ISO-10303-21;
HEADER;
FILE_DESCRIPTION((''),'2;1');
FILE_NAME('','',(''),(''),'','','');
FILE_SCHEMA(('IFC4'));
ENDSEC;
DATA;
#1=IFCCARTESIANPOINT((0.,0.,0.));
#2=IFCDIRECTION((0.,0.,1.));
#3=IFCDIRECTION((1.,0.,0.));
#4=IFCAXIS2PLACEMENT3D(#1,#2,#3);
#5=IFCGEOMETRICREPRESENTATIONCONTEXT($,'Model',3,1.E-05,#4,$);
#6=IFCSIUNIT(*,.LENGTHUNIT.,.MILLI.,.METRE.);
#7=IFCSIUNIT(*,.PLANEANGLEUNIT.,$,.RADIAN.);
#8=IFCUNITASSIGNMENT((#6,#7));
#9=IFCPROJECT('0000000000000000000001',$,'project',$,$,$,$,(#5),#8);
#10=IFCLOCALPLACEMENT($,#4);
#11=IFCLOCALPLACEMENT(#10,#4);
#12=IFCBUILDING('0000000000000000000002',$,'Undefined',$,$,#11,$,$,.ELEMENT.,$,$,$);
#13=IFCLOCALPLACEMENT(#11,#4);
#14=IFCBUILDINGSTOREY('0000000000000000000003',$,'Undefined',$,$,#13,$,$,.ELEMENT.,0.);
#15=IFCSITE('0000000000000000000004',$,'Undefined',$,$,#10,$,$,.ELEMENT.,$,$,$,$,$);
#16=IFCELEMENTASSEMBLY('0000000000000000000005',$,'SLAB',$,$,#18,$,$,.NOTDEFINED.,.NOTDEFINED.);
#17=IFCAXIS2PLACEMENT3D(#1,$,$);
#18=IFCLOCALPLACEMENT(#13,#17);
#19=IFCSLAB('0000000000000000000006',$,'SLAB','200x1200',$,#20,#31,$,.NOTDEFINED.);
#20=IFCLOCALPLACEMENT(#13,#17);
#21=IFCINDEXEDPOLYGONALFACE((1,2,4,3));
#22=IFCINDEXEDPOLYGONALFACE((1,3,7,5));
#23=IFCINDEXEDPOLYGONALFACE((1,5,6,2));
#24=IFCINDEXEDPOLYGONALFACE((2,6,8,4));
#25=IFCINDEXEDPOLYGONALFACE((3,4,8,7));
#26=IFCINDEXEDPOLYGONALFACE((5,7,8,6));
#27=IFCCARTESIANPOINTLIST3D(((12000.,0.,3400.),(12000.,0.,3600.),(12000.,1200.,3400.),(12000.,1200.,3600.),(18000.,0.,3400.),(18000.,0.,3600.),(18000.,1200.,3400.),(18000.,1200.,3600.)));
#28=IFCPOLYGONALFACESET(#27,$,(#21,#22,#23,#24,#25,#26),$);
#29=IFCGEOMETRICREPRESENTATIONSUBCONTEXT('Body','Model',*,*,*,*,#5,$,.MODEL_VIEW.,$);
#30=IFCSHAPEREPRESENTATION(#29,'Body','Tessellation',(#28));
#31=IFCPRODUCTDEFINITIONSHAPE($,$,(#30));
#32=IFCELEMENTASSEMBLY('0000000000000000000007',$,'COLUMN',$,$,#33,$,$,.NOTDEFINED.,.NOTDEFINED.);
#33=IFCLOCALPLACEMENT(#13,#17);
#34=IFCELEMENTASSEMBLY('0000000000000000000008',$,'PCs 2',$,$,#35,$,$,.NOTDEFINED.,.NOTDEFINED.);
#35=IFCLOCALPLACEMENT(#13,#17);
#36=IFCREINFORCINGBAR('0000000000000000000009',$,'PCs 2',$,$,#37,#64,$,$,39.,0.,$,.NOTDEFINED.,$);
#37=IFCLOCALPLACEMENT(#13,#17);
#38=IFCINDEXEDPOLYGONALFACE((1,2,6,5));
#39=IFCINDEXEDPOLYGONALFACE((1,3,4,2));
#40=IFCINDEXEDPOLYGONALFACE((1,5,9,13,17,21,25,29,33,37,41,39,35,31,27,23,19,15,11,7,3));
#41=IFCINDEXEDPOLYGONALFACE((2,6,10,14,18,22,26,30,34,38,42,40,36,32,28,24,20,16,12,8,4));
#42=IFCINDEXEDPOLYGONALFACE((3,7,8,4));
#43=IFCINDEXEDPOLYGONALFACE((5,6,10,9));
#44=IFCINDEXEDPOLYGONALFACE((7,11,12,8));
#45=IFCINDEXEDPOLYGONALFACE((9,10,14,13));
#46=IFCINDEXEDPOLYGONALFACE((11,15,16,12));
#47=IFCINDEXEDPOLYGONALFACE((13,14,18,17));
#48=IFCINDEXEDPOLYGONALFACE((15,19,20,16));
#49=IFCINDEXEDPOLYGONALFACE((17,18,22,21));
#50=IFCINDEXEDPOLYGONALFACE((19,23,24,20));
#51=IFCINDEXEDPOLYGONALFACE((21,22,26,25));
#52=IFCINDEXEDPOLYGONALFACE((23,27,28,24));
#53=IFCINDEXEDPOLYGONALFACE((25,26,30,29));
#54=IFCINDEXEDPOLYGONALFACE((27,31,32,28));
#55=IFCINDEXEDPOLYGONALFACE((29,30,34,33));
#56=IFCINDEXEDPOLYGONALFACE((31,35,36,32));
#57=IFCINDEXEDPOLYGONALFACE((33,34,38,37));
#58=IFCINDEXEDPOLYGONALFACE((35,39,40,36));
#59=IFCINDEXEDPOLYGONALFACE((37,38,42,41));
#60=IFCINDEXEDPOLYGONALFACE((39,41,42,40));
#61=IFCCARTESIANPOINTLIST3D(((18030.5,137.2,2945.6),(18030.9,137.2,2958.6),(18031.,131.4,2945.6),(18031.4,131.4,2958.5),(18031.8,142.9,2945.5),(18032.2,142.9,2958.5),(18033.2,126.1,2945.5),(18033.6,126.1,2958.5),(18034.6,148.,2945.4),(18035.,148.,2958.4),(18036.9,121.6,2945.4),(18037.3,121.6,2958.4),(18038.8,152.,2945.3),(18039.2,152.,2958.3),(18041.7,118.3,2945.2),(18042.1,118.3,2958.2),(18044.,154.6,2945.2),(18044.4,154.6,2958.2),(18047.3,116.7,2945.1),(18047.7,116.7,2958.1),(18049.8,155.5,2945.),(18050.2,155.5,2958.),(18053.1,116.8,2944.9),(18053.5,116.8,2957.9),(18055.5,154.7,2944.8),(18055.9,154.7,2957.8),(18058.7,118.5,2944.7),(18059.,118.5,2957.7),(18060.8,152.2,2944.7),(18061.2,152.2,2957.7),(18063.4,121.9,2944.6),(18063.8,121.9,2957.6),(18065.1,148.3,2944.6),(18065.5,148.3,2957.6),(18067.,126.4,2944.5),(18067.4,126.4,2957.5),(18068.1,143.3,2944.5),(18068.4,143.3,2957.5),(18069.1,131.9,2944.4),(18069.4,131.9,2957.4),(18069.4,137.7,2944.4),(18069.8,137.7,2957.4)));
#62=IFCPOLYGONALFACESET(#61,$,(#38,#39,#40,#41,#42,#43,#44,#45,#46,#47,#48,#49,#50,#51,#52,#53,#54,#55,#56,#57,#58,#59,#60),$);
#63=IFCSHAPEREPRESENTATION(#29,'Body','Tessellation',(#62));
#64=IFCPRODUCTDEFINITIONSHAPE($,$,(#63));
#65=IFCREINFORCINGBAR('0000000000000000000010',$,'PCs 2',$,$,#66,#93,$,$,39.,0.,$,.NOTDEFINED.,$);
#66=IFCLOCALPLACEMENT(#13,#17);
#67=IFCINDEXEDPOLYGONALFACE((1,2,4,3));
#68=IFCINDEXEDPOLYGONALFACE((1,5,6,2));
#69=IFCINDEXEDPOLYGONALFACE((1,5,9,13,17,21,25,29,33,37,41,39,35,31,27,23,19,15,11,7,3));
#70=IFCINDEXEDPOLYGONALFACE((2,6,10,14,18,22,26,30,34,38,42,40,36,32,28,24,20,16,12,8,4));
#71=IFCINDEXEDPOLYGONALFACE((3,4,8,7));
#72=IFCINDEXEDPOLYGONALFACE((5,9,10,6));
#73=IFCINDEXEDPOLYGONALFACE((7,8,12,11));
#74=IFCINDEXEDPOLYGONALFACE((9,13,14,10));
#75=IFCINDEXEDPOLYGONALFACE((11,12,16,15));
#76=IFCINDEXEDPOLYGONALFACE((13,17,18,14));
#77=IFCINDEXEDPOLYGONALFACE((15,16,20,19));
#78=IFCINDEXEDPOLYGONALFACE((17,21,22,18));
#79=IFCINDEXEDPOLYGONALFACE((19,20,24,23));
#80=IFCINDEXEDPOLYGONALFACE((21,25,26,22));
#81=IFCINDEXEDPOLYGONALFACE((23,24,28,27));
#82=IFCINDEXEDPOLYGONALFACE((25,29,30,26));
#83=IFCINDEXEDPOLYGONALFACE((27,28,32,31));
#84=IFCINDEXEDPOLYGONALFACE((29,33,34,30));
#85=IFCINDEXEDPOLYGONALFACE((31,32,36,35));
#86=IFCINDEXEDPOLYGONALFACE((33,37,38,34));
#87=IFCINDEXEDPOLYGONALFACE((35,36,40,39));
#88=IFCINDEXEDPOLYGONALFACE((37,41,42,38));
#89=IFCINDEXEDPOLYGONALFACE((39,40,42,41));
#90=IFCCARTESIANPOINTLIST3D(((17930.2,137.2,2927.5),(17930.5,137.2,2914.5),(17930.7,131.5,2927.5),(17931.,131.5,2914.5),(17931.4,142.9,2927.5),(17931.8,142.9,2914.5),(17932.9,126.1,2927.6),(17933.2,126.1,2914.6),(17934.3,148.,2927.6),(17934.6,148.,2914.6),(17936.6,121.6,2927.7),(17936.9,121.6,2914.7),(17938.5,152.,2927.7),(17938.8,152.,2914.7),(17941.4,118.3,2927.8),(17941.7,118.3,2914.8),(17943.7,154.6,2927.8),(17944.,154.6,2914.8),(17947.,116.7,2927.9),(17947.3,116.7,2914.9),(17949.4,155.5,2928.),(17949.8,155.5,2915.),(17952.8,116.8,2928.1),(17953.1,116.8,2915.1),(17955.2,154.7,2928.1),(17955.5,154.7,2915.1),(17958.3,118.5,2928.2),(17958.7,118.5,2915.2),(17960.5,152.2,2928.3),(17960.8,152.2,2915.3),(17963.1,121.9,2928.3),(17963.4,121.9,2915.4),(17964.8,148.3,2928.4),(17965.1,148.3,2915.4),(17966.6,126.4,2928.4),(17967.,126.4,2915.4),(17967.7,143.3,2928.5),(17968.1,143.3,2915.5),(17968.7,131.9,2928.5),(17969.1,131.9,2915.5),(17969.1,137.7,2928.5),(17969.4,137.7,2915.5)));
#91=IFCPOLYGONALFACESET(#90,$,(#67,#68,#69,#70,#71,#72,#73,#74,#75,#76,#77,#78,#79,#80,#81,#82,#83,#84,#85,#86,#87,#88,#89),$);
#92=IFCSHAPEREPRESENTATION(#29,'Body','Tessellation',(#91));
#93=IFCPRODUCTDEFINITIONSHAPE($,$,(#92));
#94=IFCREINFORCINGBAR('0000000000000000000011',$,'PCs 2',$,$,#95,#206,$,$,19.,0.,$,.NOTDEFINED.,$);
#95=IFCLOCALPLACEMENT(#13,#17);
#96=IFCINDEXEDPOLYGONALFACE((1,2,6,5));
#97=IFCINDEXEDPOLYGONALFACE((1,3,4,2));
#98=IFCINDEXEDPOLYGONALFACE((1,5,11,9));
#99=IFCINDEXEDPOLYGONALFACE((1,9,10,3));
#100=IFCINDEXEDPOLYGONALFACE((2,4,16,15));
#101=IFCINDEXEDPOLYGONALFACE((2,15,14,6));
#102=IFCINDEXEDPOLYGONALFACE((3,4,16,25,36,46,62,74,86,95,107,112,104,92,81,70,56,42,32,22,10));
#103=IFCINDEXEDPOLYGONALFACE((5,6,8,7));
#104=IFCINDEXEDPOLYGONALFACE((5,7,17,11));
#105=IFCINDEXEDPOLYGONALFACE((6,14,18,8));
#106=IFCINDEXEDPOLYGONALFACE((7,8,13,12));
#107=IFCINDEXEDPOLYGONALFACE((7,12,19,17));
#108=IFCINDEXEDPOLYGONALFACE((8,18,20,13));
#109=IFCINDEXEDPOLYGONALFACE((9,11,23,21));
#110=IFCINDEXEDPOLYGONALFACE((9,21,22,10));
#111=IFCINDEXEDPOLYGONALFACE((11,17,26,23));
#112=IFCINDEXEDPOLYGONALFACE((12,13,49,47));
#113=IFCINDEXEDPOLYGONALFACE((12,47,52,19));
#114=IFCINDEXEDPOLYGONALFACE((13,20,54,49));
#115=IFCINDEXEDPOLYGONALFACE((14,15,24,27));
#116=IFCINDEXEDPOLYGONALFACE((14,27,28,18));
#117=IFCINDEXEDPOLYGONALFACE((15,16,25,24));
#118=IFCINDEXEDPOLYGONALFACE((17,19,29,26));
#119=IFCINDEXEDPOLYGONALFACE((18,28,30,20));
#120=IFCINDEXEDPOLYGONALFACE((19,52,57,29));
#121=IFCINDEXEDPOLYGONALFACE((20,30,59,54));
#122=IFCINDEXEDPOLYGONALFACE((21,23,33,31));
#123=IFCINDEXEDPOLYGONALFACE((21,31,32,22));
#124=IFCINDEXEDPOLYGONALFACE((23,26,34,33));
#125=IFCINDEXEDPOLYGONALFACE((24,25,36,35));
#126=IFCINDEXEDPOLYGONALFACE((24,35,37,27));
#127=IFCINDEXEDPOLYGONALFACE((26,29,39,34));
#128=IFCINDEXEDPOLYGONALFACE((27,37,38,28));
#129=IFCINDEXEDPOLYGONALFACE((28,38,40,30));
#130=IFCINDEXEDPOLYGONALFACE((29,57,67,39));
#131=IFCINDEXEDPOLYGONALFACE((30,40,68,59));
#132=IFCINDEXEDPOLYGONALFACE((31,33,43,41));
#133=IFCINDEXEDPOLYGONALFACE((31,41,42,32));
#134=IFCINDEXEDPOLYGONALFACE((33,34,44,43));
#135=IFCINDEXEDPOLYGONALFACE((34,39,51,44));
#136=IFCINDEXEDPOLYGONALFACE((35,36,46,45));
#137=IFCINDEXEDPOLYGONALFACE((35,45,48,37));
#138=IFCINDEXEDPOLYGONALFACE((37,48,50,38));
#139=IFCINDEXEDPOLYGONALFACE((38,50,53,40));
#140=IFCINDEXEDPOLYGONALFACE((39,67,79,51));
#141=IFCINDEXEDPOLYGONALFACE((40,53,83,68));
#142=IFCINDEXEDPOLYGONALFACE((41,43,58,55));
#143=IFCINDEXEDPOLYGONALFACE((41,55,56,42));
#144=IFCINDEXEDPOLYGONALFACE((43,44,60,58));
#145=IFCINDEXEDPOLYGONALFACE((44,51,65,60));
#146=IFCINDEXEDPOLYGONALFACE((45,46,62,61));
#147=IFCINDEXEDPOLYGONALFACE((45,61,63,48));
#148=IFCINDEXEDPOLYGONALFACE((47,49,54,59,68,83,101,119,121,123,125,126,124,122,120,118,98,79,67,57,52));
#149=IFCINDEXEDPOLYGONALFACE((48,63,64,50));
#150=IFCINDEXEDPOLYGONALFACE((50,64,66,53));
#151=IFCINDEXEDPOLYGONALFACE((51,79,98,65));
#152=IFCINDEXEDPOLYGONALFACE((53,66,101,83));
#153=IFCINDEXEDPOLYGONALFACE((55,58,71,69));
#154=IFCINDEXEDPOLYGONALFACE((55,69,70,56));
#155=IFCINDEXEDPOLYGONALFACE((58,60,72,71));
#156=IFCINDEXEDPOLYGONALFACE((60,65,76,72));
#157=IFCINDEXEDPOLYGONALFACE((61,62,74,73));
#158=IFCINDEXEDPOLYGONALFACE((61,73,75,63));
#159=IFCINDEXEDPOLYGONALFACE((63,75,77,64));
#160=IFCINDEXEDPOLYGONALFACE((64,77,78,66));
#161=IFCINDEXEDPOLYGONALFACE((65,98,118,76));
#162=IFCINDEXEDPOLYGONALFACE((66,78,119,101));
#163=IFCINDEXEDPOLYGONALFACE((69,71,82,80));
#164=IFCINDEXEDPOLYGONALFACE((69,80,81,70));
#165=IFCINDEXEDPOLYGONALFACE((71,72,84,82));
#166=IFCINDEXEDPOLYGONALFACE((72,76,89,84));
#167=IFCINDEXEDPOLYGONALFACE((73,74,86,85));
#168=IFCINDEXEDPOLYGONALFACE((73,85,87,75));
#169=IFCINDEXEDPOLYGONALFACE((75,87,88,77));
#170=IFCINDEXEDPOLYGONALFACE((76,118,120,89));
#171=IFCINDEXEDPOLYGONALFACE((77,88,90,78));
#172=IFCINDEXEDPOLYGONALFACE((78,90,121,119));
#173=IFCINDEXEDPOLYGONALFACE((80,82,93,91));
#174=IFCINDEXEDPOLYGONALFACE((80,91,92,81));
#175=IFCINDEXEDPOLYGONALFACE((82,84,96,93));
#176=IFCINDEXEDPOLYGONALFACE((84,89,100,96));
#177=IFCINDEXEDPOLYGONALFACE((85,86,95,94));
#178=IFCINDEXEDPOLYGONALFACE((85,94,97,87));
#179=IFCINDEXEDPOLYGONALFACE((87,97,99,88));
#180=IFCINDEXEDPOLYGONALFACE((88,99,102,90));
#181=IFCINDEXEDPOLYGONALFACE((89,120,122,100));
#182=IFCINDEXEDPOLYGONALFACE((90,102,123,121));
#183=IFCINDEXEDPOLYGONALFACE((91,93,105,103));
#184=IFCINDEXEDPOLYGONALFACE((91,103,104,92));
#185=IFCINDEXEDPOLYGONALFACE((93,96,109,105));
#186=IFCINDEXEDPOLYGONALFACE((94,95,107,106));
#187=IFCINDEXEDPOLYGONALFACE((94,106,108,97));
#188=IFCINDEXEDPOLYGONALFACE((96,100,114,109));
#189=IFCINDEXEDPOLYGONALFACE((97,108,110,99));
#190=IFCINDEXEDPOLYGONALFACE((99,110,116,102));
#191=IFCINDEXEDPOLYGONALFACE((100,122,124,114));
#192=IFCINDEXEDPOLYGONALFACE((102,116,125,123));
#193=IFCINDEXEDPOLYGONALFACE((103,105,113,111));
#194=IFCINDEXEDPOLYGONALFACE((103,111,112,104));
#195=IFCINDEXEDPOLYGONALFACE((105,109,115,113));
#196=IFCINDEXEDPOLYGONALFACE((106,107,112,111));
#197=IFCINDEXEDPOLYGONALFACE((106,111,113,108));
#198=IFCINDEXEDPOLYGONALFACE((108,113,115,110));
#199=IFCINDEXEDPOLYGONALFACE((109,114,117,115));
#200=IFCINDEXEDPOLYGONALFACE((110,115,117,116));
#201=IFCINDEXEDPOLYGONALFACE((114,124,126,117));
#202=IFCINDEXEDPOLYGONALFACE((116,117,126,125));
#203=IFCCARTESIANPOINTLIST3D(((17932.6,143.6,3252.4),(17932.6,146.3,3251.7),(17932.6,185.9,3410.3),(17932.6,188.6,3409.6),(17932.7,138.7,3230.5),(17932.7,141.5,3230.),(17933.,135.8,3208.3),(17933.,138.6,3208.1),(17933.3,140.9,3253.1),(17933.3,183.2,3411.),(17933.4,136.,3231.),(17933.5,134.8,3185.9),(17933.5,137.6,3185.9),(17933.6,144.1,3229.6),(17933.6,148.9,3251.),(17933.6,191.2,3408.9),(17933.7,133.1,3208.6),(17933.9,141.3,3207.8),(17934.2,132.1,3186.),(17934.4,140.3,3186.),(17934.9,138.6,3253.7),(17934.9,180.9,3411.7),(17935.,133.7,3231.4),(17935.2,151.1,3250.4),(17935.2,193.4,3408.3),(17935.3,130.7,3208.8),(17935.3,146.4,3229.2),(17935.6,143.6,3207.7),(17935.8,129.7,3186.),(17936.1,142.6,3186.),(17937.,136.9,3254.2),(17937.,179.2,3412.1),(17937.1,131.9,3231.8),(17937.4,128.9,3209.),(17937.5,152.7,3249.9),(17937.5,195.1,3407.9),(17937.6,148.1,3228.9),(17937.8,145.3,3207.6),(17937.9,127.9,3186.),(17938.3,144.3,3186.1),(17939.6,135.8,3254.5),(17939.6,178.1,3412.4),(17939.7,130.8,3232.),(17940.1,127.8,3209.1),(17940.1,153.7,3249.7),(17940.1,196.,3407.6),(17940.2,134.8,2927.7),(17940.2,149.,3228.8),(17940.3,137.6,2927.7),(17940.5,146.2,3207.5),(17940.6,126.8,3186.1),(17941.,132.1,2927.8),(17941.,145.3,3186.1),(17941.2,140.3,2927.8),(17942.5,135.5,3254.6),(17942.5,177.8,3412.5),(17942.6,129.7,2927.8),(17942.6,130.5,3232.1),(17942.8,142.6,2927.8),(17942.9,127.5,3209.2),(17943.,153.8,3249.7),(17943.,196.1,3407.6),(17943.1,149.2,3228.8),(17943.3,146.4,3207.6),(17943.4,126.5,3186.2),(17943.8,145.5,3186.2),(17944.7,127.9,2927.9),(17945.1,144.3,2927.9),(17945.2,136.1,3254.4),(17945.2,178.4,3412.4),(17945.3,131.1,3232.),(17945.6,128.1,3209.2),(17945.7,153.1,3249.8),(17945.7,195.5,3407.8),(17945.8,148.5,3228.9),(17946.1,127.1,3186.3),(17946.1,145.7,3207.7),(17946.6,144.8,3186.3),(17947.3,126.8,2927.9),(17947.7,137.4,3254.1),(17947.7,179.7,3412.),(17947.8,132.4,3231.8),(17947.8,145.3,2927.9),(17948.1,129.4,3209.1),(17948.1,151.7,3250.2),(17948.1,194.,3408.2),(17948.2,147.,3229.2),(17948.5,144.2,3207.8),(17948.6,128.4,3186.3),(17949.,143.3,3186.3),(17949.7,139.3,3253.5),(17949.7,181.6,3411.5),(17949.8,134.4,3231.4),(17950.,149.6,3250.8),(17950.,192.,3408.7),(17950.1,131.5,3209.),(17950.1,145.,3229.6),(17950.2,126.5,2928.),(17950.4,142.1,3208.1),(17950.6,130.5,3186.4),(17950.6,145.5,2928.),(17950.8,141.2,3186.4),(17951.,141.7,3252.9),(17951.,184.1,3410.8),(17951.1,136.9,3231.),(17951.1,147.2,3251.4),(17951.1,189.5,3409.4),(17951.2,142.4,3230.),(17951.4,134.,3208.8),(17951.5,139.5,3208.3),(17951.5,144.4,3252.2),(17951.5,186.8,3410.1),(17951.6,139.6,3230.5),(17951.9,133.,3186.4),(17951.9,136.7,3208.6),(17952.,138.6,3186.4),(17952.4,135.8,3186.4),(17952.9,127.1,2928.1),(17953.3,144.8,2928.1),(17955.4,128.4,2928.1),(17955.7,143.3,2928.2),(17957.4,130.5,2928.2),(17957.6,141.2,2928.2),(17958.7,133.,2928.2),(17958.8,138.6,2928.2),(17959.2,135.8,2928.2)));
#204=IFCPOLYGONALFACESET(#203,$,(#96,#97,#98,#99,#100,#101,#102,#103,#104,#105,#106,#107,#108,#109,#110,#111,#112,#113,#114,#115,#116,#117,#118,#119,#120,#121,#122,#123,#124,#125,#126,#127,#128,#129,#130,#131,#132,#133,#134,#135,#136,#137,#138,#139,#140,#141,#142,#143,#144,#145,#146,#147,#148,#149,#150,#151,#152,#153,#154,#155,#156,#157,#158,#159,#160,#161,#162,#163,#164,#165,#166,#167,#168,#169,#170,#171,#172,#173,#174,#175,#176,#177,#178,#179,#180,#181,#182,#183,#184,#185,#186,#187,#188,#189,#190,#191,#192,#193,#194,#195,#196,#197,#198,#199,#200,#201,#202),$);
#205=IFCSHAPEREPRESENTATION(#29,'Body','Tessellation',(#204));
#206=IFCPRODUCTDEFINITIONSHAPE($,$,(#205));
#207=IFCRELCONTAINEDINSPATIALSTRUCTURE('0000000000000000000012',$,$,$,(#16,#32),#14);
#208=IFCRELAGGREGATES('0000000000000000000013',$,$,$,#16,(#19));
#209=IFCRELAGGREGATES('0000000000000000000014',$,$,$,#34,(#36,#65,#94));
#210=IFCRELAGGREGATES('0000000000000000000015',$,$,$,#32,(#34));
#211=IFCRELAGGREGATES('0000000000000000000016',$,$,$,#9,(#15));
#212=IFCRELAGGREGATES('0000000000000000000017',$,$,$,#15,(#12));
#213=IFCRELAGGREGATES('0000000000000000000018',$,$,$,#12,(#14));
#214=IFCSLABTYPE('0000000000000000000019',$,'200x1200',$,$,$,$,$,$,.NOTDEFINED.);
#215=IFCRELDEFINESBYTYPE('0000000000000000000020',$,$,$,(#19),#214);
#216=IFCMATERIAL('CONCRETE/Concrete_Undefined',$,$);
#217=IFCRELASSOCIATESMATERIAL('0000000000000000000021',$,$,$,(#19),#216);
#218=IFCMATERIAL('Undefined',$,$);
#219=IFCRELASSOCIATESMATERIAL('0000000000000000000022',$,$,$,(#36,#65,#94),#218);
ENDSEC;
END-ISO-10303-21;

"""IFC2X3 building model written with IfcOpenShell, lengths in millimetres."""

from ifc_helpers import new_model, entity, si_unit, frame, origin_with_axes, place, context, subcontext, project, spatial, polyline, outline, extrude, source, transform, mapped, material, type_object, element, aggregate, save


model = new_model("IFC2X3")

# Units and contexts
model_context = context("Model", 3, precision=1e-05, world=origin_with_axes())
body_context = subcontext(model_context, "Body", "Model", "MODEL_VIEW")
ifc_project = project(units=[si_unit("LENGTHUNIT", "METRE", prefix="MILLI"), si_unit("PLANEANGLEUNIT", "RADIAN")], contexts=[model_context])

# Site, building, storey
site_placement = place(None, origin_with_axes())
site = spatial("IfcSite", under=ifc_project, at=site_placement, Name="Undefined", CompositionType="ELEMENT")
building_placement = place(site_placement, origin_with_axes())
building = spatial("IfcBuilding", under=site, at=building_placement, Name="Undefined", CompositionType="ELEMENT")
storey_placement = place(building_placement, origin_with_axes())
storey = spatial("IfcBuildingStorey", under=building, at=storey_placement, Name="Undefined", CompositionType="ELEMENT", Elevation=0.0)

# Element assembly, slab
assembly_1_placement = place(storey_placement, origin_with_axes())
assembly_1 = element("IfcElementAssembly", 1, at=assembly_1_placement, inside=storey, Name="SLAB", AssemblyPlace="NOTDEFINED", PredefinedType="NOTDEFINED")
ifc_material_1 = material(Name="CONCRETE/Concrete_Undefined")
slab_type = type_object("IfcSlabType", Name="200x1200", PredefinedType="NOTDEFINED")
slab_placement = place(assembly_1_placement, frame((18000.0, 0.0, 3500.0), z_axis=(0.0, 0.0, 1.0), x_axis=(0.0, 1.0, 0.0)))
slab = element("IfcSlab", 2, at=slab_placement, type_object=slab_type, material=ifc_material_1, Name="SLAB", Description="200x1200", PredefinedType="NOTDEFINED", context=body_context, shape_type="SweptSolid", body=[
    extrude(outline(polyline([(0.0, 0.0), (1200.0, 0.0), (1200.0, 6000.0), (0.0, 6000.0), (0.0, 0.0)])), frame((0.0, 0.0, -100.0), z_axis=(0.0, 0.0, 1.0), x_axis=(1.0, 0.0, 0.0)), (0.0, 0.0, 1.0), 200.0),
])
aggregate(assembly_1, [slab])

# Shared definitions
ifc_material_2 = material(Name="Undefined")

# Element assemblies, reinforcing bars
assembly_2_placement = place(storey_placement, origin_with_axes())
assembly_2 = element("IfcElementAssembly", 3, at=assembly_2_placement, inside=storey, Name="COLUMN", AssemblyPlace="NOTDEFINED", PredefinedType="NOTDEFINED")
assembly_3_placement = place(assembly_2_placement, origin_with_axes())
assembly_3 = element("IfcElementAssembly", 4, at=assembly_3_placement, Name="PCs 2", AssemblyPlace="NOTDEFINED", PredefinedType="NOTDEFINED")
shared_shape_1 = source(origin_with_axes(), body_context, "Body", "AdvancedSweptSolid", [
    entity("IfcSweptDiskSolid", entity("IfcTrimmedCurve", entity("IfcLine", entity("IfcCartesianPoint", [0.0, 0.0, 0.0]), entity("IfcVector", entity("IfcDirection", [1.0, 0.0, 0.0]), 1.0)), [entity("IfcParameterValue", 0.0)], [entity("IfcParameterValue", 13.0)], True, "PARAMETER"), 19.5, None, 0.0, 13.0),
])
reinforcing_bar_1_placement = place(assembly_3_placement, frame((18050.4, 136.0, 2958.0), z_axis=(-0.011171, 0.999938, 0.000325), x_axis=(-0.02911, 0.0, -0.999576)))
reinforcing_bar_1 = element("IfcReinforcingBar", 5, at=reinforcing_bar_1_placement, material=ifc_material_2, Name="PCs 2", BarRole="NOTDEFINED", CrossSectionArea=0.0, NominalDiameter=39.0, context=body_context, shape_type="MappedRepresentation", body=[
    mapped(shared_shape_1, transform((0.0, 0.0, 0.0))),
])
shared_shape_2 = source(origin_with_axes(), body_context, "Body", "AdvancedSweptSolid", [
    entity("IfcSweptDiskSolid", entity("IfcTrimmedCurve", entity("IfcLine", entity("IfcCartesianPoint", [0.0, 0.0, 0.0]), entity("IfcVector", entity("IfcDirection", [1.0, 0.0, 0.0]), 1.0)), [entity("IfcParameterValue", 0.0)], [entity("IfcParameterValue", 13.0)], True, "PARAMETER"), 19.5, None, 0.0, 13.0),
])
reinforcing_bar_2_placement = place(assembly_3_placement, frame((17949.7, 136.0, 2928.0), z_axis=(-0.011057, 0.999939, -0.00029), x_axis=(0.026246, 0.0, -0.999656)))
reinforcing_bar_2 = element("IfcReinforcingBar", 6, at=reinforcing_bar_2_placement, material=ifc_material_2, Name="PCs 2", BarRole="NOTDEFINED", CrossSectionArea=0.0, NominalDiameter=39.0, context=body_context, shape_type="MappedRepresentation", body=[
    mapped(shared_shape_2, transform((0.0, 0.0, 0.0))),
])
shared_shape_3 = source(origin_with_axes(), body_context, "Body", "AdvancedSweptSolid", [
    entity("IfcSweptDiskSolid", entity("IfcCompositeCurve", [entity("IfcCompositeCurveSegment", "CONTINUOUS", True, entity("IfcTrimmedCurve", entity("IfcLine", entity("IfcCartesianPoint", [0.0, 0.0, 0.0]), entity("IfcVector", entity("IfcDirection", [0.965593, 0.0, -0.260058]), 1.0)), [entity("IfcParameterValue", 0.0)], [entity("IfcParameterValue", 163.509567)], True, "PARAMETER")), entity("IfcCompositeCurveSegment", "CONTINUOUS", True, entity("IfcTrimmedCurve", entity("IfcCircle", entity("IfcAxis2Placement3D", entity("IfcCartesianPoint", [223.8, 0.0, 202.3]), entity("IfcDirection", [0.0, -1.0, 0.0]), entity("IfcDirection", [-0.260058, 0.0, -0.965593])), 253.5), [entity("IfcParameterValue", 0.0)], [entity("IfcParameterValue", 0.263082)], True, "PARAMETER")), entity("IfcCompositeCurveSegment", "DISCONTINUOUS", True, entity("IfcTrimmedCurve", entity("IfcLine", entity("IfcCartesianPoint", [223.8, 0.0, -51.2]), entity("IfcVector", entity("IfcDirection", [1.0, 0.0, 0.0]), 1.0)), [entity("IfcParameterValue", 0.0)], [entity("IfcParameterValue", 258.272327)], True, "PARAMETER"))], False), 9.5, None, 0.0, 422.0),
])
reinforcing_bar_3_placement = place(assembly_3_placement, frame((17942.0, 136.0, 3219.7), z_axis=(0.09745, 0.995237, 0.002559), x_axis=(0.026246, 0.0, -0.999656)))
reinforcing_bar_3 = element("IfcReinforcingBar", 7, at=reinforcing_bar_3_placement, material=ifc_material_2, Name="PCs 2", BarRole="NOTDEFINED", CrossSectionArea=0.0, NominalDiameter=19.0, context=body_context, shape_type="MappedRepresentation", body=[
    mapped(shared_shape_3, transform((-190.3, 0.0, 51.2))),
])
aggregate(assembly_3, [reinforcing_bar_1, reinforcing_bar_2, reinforcing_bar_3])
aggregate(assembly_2, [assembly_3])

save(model, "model.ifc")
